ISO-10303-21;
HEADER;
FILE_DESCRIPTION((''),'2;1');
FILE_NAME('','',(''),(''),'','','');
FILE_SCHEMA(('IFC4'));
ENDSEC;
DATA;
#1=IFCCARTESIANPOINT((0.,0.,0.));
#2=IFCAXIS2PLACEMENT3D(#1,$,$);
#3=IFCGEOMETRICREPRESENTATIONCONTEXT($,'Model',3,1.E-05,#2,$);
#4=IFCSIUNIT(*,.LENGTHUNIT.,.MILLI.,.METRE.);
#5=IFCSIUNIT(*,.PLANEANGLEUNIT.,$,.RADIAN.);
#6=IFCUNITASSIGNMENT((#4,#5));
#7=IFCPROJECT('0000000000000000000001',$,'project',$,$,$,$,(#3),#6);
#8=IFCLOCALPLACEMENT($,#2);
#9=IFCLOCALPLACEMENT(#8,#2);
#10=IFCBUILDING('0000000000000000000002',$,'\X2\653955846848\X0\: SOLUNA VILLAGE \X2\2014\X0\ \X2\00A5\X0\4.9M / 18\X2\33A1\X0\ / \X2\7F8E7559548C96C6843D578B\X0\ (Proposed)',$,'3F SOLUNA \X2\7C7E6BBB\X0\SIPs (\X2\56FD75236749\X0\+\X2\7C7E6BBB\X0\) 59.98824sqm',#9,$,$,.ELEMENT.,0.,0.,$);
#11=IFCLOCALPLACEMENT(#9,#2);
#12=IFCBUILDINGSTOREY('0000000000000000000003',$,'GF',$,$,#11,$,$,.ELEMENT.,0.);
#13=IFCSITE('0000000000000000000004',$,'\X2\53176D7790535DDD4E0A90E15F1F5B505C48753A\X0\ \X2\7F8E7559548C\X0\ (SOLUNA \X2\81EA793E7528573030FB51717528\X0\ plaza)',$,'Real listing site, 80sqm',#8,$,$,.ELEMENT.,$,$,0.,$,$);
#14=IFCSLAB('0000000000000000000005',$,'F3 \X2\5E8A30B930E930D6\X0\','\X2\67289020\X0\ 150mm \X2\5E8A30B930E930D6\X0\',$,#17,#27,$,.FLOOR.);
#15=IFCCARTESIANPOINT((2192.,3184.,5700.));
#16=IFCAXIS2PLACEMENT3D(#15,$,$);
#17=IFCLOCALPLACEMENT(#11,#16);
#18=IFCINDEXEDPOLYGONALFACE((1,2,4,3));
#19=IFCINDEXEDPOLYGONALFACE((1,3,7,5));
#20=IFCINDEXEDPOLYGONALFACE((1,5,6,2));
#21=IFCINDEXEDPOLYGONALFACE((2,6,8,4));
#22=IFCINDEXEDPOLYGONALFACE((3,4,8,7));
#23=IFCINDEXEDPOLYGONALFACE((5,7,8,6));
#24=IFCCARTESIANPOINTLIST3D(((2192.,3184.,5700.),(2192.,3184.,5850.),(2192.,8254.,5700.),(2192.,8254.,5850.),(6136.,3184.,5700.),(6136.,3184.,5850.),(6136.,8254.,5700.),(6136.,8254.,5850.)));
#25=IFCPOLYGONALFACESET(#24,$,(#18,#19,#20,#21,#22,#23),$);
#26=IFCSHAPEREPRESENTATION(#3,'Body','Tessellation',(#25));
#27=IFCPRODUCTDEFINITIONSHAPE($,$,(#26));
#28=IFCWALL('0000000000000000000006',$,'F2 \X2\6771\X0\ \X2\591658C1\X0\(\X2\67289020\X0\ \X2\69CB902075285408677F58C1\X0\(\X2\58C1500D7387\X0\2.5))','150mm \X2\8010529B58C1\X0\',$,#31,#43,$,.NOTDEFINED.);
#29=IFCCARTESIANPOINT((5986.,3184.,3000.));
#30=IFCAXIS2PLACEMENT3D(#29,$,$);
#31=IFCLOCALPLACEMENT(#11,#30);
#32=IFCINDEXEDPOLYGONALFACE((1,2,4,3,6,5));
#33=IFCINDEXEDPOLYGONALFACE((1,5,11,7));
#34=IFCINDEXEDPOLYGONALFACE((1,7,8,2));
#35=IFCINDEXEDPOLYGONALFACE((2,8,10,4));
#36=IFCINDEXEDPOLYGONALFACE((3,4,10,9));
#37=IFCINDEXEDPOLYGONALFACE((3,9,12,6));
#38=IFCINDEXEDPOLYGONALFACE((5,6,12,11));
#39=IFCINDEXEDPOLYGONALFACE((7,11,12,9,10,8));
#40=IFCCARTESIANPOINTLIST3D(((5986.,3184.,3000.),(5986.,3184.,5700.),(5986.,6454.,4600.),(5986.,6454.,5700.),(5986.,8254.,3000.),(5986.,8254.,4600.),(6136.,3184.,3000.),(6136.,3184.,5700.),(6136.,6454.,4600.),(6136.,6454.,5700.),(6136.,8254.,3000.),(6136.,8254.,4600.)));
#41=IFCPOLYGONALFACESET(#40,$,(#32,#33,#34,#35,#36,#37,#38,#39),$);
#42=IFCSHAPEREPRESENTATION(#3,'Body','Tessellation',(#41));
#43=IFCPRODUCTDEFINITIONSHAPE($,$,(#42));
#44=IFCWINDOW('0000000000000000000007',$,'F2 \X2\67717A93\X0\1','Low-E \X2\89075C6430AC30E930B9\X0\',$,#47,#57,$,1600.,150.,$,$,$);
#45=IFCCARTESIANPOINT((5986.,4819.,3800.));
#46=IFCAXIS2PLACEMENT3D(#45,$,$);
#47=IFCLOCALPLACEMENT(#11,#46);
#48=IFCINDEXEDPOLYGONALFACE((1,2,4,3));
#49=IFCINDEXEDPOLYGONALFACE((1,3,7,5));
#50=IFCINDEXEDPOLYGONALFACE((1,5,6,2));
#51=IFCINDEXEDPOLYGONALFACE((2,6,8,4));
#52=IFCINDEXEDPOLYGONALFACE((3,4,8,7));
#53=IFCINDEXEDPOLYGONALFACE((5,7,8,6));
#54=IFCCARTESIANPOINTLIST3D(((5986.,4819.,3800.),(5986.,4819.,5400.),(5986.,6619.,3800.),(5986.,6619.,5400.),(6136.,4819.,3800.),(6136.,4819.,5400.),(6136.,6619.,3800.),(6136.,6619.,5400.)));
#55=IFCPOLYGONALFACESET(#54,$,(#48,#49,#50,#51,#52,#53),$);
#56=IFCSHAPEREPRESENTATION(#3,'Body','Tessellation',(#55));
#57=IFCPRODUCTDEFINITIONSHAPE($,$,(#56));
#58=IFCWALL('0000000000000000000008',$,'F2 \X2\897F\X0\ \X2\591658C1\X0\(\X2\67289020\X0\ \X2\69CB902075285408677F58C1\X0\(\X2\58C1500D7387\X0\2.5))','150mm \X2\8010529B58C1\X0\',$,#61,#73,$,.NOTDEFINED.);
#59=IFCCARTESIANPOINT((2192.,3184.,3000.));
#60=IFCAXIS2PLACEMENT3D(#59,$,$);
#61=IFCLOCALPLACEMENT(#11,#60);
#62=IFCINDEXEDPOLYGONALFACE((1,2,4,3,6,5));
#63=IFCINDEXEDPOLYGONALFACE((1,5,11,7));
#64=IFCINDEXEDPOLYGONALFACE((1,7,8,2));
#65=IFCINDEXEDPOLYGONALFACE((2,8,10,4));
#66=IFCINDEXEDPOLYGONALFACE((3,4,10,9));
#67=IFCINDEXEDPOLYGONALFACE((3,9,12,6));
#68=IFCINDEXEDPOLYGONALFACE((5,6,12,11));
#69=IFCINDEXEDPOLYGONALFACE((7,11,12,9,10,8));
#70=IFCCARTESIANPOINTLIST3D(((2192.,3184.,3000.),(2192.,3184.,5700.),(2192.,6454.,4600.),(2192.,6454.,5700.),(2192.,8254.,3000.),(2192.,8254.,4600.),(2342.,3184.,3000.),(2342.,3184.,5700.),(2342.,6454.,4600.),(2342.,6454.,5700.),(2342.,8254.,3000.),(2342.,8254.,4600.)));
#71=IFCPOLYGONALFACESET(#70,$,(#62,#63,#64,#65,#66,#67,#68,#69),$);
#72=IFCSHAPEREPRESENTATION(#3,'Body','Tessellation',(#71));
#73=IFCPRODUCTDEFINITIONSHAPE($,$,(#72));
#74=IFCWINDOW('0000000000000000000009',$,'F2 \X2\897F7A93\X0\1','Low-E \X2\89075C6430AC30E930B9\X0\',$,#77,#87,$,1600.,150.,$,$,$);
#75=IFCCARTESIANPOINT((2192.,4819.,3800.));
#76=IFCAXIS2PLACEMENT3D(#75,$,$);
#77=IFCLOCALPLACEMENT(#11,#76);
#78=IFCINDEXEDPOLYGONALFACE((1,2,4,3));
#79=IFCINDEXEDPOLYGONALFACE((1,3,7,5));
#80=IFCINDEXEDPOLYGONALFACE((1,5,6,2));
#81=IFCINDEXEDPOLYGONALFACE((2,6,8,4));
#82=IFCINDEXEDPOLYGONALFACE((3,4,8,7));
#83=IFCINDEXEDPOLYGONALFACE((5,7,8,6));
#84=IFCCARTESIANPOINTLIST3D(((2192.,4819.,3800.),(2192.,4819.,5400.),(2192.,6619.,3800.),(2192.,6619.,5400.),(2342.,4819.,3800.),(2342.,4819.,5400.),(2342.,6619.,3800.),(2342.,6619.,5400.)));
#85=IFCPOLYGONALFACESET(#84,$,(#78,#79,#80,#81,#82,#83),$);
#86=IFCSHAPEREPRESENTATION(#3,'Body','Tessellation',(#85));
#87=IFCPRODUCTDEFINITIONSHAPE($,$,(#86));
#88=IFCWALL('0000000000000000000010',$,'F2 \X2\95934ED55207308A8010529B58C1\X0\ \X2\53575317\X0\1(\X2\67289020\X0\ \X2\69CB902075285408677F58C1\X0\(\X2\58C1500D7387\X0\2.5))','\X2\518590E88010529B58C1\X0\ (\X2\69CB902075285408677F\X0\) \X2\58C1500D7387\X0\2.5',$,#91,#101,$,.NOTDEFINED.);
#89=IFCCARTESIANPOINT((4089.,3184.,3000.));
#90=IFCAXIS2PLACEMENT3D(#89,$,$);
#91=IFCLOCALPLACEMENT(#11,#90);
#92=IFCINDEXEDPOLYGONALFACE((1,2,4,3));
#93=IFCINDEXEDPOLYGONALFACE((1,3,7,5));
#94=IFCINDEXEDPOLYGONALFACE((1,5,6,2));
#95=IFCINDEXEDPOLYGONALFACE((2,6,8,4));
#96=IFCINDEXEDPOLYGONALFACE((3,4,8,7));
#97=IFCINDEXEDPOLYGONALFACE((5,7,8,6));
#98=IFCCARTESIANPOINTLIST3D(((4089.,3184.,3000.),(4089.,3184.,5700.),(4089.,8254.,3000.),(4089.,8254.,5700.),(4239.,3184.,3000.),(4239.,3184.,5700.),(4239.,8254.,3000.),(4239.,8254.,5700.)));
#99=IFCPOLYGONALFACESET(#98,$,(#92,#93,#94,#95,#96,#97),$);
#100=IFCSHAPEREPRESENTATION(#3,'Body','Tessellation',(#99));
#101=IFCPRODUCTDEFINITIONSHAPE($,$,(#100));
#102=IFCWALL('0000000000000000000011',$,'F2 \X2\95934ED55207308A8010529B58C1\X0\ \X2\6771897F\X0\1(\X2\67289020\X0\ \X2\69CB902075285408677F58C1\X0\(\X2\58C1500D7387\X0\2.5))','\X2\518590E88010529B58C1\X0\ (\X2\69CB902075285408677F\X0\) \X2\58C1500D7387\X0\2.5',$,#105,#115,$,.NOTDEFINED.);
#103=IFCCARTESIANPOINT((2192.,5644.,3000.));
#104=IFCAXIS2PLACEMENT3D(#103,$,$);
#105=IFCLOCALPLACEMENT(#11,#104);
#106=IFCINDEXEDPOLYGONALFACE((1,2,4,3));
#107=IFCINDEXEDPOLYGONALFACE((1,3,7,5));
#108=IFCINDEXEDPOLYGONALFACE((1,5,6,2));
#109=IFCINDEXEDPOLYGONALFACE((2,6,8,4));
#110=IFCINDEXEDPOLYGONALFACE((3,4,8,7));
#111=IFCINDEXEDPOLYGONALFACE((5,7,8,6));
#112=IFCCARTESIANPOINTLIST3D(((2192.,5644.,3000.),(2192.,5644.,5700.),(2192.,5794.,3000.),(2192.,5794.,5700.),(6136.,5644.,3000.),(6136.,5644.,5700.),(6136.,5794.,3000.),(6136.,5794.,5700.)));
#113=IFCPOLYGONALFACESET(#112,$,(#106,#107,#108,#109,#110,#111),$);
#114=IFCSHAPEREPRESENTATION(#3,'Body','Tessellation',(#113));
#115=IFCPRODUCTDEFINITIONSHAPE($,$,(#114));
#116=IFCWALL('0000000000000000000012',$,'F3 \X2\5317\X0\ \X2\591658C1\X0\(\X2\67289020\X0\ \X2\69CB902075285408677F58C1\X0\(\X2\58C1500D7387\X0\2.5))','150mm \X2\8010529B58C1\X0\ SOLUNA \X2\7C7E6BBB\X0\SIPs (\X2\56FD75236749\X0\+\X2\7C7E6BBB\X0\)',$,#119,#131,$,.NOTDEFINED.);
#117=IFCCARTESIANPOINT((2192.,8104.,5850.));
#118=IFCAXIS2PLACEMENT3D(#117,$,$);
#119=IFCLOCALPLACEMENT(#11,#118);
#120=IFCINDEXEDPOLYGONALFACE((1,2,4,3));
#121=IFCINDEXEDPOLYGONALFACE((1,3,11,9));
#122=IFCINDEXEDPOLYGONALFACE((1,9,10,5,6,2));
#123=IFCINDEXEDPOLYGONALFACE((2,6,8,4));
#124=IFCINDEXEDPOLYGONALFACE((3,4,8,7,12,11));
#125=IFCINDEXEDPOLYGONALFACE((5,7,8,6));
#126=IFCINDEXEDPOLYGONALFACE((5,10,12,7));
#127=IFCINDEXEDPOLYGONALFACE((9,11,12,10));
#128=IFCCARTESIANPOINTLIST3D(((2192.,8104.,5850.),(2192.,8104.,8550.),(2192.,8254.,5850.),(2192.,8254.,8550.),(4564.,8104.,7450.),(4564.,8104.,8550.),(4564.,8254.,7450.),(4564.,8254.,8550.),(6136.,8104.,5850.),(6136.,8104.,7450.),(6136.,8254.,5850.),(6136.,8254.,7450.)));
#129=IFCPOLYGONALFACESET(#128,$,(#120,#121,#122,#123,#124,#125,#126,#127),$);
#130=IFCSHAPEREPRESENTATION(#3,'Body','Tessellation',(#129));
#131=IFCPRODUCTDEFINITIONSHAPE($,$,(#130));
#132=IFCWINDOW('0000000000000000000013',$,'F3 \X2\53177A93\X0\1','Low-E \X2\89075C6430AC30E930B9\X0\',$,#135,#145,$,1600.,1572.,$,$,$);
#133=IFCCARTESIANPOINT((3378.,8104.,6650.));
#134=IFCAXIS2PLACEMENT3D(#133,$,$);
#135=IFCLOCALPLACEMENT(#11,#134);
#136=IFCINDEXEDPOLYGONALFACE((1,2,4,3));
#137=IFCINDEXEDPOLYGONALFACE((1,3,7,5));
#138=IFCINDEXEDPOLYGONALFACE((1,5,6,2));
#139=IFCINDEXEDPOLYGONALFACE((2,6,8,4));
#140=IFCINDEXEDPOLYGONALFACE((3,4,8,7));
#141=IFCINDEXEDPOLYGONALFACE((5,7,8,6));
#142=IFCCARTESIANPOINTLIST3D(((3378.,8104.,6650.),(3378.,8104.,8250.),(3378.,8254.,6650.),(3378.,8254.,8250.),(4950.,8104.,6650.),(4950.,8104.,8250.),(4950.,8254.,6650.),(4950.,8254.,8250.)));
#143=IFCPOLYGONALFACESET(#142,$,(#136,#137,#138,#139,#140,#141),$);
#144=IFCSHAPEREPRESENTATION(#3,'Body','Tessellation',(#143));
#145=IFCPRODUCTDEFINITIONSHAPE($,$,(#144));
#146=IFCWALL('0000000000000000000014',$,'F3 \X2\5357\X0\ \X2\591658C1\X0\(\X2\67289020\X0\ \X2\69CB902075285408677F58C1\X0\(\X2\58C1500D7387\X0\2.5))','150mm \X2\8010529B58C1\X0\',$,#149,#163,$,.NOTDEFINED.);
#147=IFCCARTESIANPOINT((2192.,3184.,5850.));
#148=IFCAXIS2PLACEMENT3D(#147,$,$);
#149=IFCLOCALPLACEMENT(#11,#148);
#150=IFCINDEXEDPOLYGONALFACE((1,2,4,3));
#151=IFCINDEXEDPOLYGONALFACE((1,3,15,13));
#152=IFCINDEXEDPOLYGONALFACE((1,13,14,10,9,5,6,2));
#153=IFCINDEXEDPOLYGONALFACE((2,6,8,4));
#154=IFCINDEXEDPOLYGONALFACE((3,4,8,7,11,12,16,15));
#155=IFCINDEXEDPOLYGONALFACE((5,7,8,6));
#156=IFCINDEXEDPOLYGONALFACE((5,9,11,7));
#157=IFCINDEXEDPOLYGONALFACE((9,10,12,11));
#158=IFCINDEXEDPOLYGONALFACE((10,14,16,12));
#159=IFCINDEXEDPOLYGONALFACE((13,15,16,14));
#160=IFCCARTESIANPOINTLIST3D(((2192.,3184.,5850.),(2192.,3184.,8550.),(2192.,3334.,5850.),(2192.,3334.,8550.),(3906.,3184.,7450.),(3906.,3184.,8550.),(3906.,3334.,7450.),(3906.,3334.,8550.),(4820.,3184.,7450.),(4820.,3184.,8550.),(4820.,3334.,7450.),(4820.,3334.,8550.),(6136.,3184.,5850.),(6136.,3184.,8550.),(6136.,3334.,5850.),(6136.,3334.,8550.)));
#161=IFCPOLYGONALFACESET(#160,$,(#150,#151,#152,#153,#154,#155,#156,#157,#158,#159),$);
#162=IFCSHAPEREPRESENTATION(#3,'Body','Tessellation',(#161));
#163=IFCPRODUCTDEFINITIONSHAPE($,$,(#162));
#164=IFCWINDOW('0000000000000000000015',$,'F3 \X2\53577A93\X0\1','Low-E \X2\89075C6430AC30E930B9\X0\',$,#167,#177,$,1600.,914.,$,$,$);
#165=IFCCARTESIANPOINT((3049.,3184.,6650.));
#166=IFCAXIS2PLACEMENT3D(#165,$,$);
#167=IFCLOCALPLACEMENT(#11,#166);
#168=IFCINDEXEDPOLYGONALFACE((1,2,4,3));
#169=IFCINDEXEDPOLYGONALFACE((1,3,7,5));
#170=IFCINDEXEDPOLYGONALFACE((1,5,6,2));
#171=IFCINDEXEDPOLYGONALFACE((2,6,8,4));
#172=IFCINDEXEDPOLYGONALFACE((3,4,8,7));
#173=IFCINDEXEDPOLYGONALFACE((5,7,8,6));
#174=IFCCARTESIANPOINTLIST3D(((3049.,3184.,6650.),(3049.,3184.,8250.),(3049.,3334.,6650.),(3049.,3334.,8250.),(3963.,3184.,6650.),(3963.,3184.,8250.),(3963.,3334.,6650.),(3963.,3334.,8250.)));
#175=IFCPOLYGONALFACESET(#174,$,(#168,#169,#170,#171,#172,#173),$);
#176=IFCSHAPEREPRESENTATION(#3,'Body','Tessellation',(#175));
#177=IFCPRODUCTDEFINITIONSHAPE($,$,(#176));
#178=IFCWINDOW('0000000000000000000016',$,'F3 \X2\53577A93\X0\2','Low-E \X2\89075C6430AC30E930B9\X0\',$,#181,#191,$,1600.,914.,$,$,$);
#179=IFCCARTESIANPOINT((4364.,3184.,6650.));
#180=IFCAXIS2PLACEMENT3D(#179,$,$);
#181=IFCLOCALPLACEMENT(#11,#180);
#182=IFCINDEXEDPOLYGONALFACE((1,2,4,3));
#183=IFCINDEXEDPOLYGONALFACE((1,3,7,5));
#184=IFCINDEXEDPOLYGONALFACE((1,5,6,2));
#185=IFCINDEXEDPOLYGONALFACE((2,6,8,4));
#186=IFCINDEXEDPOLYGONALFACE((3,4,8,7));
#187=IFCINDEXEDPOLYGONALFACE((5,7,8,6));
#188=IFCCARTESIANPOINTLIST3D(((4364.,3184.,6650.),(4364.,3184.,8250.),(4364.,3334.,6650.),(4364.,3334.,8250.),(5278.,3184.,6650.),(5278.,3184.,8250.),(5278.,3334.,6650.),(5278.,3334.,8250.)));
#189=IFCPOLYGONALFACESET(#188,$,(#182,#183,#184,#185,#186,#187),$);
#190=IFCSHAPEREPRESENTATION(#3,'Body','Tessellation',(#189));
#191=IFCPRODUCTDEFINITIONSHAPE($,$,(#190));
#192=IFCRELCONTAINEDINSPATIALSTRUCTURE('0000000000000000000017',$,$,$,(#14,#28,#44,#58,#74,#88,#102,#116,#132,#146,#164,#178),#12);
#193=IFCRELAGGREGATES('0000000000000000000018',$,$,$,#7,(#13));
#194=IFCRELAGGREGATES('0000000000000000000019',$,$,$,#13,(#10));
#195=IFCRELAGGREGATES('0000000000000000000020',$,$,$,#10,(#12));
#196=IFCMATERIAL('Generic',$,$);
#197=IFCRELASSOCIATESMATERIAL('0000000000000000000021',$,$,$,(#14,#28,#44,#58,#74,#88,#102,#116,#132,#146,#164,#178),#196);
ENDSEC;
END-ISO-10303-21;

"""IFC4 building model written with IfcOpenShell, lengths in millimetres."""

from ifc_helpers import new_model, si_unit, frame, frame_2d, origin, place, context, project, spatial, rectangle, extrude, material, element, fill, save


model = new_model("IFC4")

# Units and contexts
model_context = context("Model", 3, precision=1e-05, world=origin())
ifc_project = project(units=[si_unit("LENGTHUNIT", "METRE", prefix="MILLI"), si_unit("PLANEANGLEUNIT", "RADIAN")], contexts=[model_context])

# Site, building, storey
site_placement = place(None, origin())
site = spatial("IfcSite", under=ifc_project, at=site_placement, Name="北海道川上郡弟子屈町 美留和 (SOLUNA 自社用地・共用 plaza)", ObjectType="Real listing site, 80sqm", CompositionType="ELEMENT", RefElevation=0.0)
building_placement = place(site_placement, origin())
building = spatial("IfcBuilding", under=site, at=building_placement, Name="改善案: SOLUNA VILLAGE — ¥4.9M / 18㎡ / 美留和集落型 (Proposed)", ObjectType="3F SOLUNA 籾殻SIPs (国産杉+籾殻) 59.98824sqm", CompositionType="ELEMENT", ElevationOfRefHeight=0.0, ElevationOfTerrain=0.0)
storey_placement = place(building_placement, origin())
storey = spatial("IfcBuildingStorey", under=building, at=storey_placement, Name="GF", CompositionType="ELEMENT", Elevation=0.0)

# Slab
ifc_material_1 = material(Name="Generic")
slab_placement = place(storey_placement, frame((2192.0, 3184.0, 5700.0)))
element("IfcSlab", 1, at=slab_placement, inside=storey, material=ifc_material_1, Name="F3 床スラブ", Description="木造 150mm 床スラブ", PredefinedType="FLOOR", context=model_context, shape_type="SweptSolid", body=[
    extrude(rectangle(XDim=3944.0, YDim=5070.0, at=frame_2d((1972.0, 2535.0))), frame((2192.0, 3184.0, 5700.0)), (0.0, 0.0, 1.0), 150.0),
])

# Walls, openings, windows
wall_1_placement = place(storey_placement, frame((5986.0, 3184.0, 3000.0)))
wall_1 = element("IfcWall", 2, at=wall_1_placement, inside=storey, material=ifc_material_1, Name="F2 東 外壁(木造 構造用合板壁(壁倍率2.5))", Description="150mm 耐力壁", PredefinedType="NOTDEFINED", context=model_context, shape_type="SweptSolid", body=[
    extrude(rectangle(XDim=150.0, YDim=5070.0, at=frame_2d((75.0, 2535.0))), frame((5986.0, 3184.0, 3000.0)), (0.0, 0.0, 1.0), 2700.0),
])
opening_1_placement = place(storey_placement, frame((5986.0, 4819.0, 3800.0)))
opening_1 = element("IfcOpeningElement", 3, at=opening_1_placement, cuts=wall_1, PredefinedType="NOTDEFINED", context=model_context, shape_type="SweptSolid", body=[
    extrude(rectangle(XDim=150.0, YDim=1800.0, at=frame_2d((75.0, 900.0))), frame((5986.0, 4819.0, 3800.0)), (0.0, 0.0, 1.0), 1600.0),
])
window_1_placement = place(storey_placement, frame((5986.0, 4819.0, 3800.0)))
window_1 = element("IfcWindow", 4, at=window_1_placement, inside=storey, material=ifc_material_1, Name="F2 東窓1", Description="Low-E 複層ガラス", OverallHeight=1600.0, OverallWidth=150.0, context=model_context, shape_type="SweptSolid", body=[
    extrude(rectangle(XDim=150.0, YDim=1800.0, at=frame_2d((75.0, 900.0))), frame((5986.0, 4819.0, 3800.0)), (0.0, 0.0, 1.0), 1600.0),
])
fill(opening_1, window_1)
wall_2_placement = place(storey_placement, frame((2192.0, 3184.0, 3000.0)))
wall_2 = element("IfcWall", 5, at=wall_2_placement, inside=storey, material=ifc_material_1, Name="F2 西 外壁(木造 構造用合板壁(壁倍率2.5))", Description="150mm 耐力壁", PredefinedType="NOTDEFINED", context=model_context, shape_type="SweptSolid", body=[
    extrude(rectangle(XDim=150.0, YDim=5070.0, at=frame_2d((75.0, 2535.0))), frame((2192.0, 3184.0, 3000.0)), (0.0, 0.0, 1.0), 2700.0),
])
opening_2_placement = place(storey_placement, frame((2192.0, 4819.0, 3800.0)))
opening_2 = element("IfcOpeningElement", 6, at=opening_2_placement, cuts=wall_2, PredefinedType="NOTDEFINED", context=model_context, shape_type="SweptSolid", body=[
    extrude(rectangle(XDim=150.0, YDim=1800.0, at=frame_2d((75.0, 900.0))), frame((2192.0, 4819.0, 3800.0)), (0.0, 0.0, 1.0), 1600.0),
])
window_2_placement = place(storey_placement, frame((2192.0, 4819.0, 3800.0)))
window_2 = element("IfcWindow", 7, at=window_2_placement, inside=storey, material=ifc_material_1, Name="F2 西窓1", Description="Low-E 複層ガラス", OverallHeight=1600.0, OverallWidth=150.0, context=model_context, shape_type="SweptSolid", body=[
    extrude(rectangle(XDim=150.0, YDim=1800.0, at=frame_2d((75.0, 900.0))), frame((2192.0, 4819.0, 3800.0)), (0.0, 0.0, 1.0), 1600.0),
])
fill(opening_2, window_2)

# Walls
wall_3_placement = place(storey_placement, frame((4089.0, 3184.0, 3000.0)))
element("IfcWall", 8, at=wall_3_placement, inside=storey, material=ifc_material_1, Name="F2 間仕切り耐力壁 南北1(木造 構造用合板壁(壁倍率2.5))", Description="内部耐力壁 (構造用合板) 壁倍率2.5", PredefinedType="NOTDEFINED", context=model_context, shape_type="SweptSolid", body=[
    extrude(rectangle(XDim=150.0, YDim=5070.0, at=frame_2d((75.0, 2535.0))), frame((4089.0, 3184.0, 3000.0)), (0.0, 0.0, 1.0), 2700.0),
])
wall_4_placement = place(storey_placement, frame((2192.0, 5644.0, 3000.0)))
element("IfcWall", 9, at=wall_4_placement, inside=storey, material=ifc_material_1, Name="F2 間仕切り耐力壁 東西1(木造 構造用合板壁(壁倍率2.5))", Description="内部耐力壁 (構造用合板) 壁倍率2.5", PredefinedType="NOTDEFINED", context=model_context, shape_type="SweptSolid", body=[
    extrude(rectangle(XDim=3944.0, YDim=150.0, at=frame_2d((1972.0, 75.0))), frame((2192.0, 5644.0, 3000.0)), (0.0, 0.0, 1.0), 2700.0),
])

# Wall, opening, window
wall_5_placement = place(storey_placement, frame((2192.0, 8104.0, 5850.0)))
wall_5 = element("IfcWall", 10, at=wall_5_placement, inside=storey, material=ifc_material_1, Name="F3 北 外壁(木造 構造用合板壁(壁倍率2.5))", Description="150mm 耐力壁 SOLUNA 籾殻SIPs (国産杉+籾殻)", PredefinedType="NOTDEFINED", context=model_context, shape_type="SweptSolid", body=[
    extrude(rectangle(XDim=3944.0, YDim=150.0, at=frame_2d((1972.0, 75.0))), frame((2192.0, 8104.0, 5850.0)), (0.0, 0.0, 1.0), 2700.0),
])
opening_3_placement = place(storey_placement, frame((3378.0, 8104.0, 6650.0)))
opening_3 = element("IfcOpeningElement", 11, at=opening_3_placement, cuts=wall_5, PredefinedType="NOTDEFINED", context=model_context, shape_type="SweptSolid", body=[
    extrude(rectangle(XDim=1572.0, YDim=150.0, at=frame_2d((786.0, 75.0))), frame((3378.0, 8104.0, 6650.0)), (0.0, 0.0, 1.0), 1600.0),
])
window_3_placement = place(storey_placement, frame((3378.0, 8104.0, 6650.0)))
window_3 = element("IfcWindow", 12, at=window_3_placement, inside=storey, material=ifc_material_1, Name="F3 北窓1", Description="Low-E 複層ガラス", OverallHeight=1600.0, OverallWidth=1572.0, context=model_context, shape_type="SweptSolid", body=[
    extrude(rectangle(XDim=1572.0, YDim=150.0, at=frame_2d((786.0, 75.0))), frame((3378.0, 8104.0, 6650.0)), (0.0, 0.0, 1.0), 1600.0),
])
fill(opening_3, window_3)

# Wall, openings, windows
wall_6_placement = place(storey_placement, frame((2192.0, 3184.0, 5850.0)))
wall_6 = element("IfcWall", 13, at=wall_6_placement, inside=storey, material=ifc_material_1, Name="F3 南 外壁(木造 構造用合板壁(壁倍率2.5))", Description="150mm 耐力壁", PredefinedType="NOTDEFINED", context=model_context, shape_type="SweptSolid", body=[
    extrude(rectangle(XDim=3944.0, YDim=150.0, at=frame_2d((1972.0, 75.0))), frame((2192.0, 3184.0, 5850.0)), (0.0, 0.0, 1.0), 2700.0),
])
opening_4_placement = place(storey_placement, frame((3049.0, 3184.0, 6650.0)))
opening_4 = element("IfcOpeningElement", 14, at=opening_4_placement, cuts=wall_6, PredefinedType="NOTDEFINED", context=model_context, shape_type="SweptSolid", body=[
    extrude(rectangle(XDim=914.0, YDim=150.0, at=frame_2d((457.0, 75.0))), frame((3049.0, 3184.0, 6650.0)), (0.0, 0.0, 1.0), 1600.0),
])
opening_5_placement = place(storey_placement, frame((4364.0, 3184.0, 6650.0)))
opening_5 = element("IfcOpeningElement", 15, at=opening_5_placement, cuts=wall_6, PredefinedType="NOTDEFINED", context=model_context, shape_type="SweptSolid", body=[
    extrude(rectangle(XDim=914.0, YDim=150.0, at=frame_2d((457.0, 75.0))), frame((4364.0, 3184.0, 6650.0)), (0.0, 0.0, 1.0), 1600.0),
])
window_4_placement = place(storey_placement, frame((3049.0, 3184.0, 6650.0)))
window_4 = element("IfcWindow", 16, at=window_4_placement, inside=storey, material=ifc_material_1, Name="F3 南窓1", Description="Low-E 複層ガラス", OverallHeight=1600.0, OverallWidth=914.0, context=model_context, shape_type="SweptSolid", body=[
    extrude(rectangle(XDim=914.0, YDim=150.0, at=frame_2d((457.0, 75.0))), frame((3049.0, 3184.0, 6650.0)), (0.0, 0.0, 1.0), 1600.0),
])
fill(opening_4, window_4)
window_5_placement = place(storey_placement, frame((4364.0, 3184.0, 6650.0)))
window_5 = element("IfcWindow", 17, at=window_5_placement, inside=storey, material=ifc_material_1, Name="F3 南窓2", Description="Low-E 複層ガラス", OverallHeight=1600.0, OverallWidth=914.0, context=model_context, shape_type="SweptSolid", body=[
    extrude(rectangle(XDim=914.0, YDim=150.0, at=frame_2d((457.0, 75.0))), frame((4364.0, 3184.0, 6650.0)), (0.0, 0.0, 1.0), 1600.0),
])
fill(opening_5, window_5)

save(model, "model.ifc")
